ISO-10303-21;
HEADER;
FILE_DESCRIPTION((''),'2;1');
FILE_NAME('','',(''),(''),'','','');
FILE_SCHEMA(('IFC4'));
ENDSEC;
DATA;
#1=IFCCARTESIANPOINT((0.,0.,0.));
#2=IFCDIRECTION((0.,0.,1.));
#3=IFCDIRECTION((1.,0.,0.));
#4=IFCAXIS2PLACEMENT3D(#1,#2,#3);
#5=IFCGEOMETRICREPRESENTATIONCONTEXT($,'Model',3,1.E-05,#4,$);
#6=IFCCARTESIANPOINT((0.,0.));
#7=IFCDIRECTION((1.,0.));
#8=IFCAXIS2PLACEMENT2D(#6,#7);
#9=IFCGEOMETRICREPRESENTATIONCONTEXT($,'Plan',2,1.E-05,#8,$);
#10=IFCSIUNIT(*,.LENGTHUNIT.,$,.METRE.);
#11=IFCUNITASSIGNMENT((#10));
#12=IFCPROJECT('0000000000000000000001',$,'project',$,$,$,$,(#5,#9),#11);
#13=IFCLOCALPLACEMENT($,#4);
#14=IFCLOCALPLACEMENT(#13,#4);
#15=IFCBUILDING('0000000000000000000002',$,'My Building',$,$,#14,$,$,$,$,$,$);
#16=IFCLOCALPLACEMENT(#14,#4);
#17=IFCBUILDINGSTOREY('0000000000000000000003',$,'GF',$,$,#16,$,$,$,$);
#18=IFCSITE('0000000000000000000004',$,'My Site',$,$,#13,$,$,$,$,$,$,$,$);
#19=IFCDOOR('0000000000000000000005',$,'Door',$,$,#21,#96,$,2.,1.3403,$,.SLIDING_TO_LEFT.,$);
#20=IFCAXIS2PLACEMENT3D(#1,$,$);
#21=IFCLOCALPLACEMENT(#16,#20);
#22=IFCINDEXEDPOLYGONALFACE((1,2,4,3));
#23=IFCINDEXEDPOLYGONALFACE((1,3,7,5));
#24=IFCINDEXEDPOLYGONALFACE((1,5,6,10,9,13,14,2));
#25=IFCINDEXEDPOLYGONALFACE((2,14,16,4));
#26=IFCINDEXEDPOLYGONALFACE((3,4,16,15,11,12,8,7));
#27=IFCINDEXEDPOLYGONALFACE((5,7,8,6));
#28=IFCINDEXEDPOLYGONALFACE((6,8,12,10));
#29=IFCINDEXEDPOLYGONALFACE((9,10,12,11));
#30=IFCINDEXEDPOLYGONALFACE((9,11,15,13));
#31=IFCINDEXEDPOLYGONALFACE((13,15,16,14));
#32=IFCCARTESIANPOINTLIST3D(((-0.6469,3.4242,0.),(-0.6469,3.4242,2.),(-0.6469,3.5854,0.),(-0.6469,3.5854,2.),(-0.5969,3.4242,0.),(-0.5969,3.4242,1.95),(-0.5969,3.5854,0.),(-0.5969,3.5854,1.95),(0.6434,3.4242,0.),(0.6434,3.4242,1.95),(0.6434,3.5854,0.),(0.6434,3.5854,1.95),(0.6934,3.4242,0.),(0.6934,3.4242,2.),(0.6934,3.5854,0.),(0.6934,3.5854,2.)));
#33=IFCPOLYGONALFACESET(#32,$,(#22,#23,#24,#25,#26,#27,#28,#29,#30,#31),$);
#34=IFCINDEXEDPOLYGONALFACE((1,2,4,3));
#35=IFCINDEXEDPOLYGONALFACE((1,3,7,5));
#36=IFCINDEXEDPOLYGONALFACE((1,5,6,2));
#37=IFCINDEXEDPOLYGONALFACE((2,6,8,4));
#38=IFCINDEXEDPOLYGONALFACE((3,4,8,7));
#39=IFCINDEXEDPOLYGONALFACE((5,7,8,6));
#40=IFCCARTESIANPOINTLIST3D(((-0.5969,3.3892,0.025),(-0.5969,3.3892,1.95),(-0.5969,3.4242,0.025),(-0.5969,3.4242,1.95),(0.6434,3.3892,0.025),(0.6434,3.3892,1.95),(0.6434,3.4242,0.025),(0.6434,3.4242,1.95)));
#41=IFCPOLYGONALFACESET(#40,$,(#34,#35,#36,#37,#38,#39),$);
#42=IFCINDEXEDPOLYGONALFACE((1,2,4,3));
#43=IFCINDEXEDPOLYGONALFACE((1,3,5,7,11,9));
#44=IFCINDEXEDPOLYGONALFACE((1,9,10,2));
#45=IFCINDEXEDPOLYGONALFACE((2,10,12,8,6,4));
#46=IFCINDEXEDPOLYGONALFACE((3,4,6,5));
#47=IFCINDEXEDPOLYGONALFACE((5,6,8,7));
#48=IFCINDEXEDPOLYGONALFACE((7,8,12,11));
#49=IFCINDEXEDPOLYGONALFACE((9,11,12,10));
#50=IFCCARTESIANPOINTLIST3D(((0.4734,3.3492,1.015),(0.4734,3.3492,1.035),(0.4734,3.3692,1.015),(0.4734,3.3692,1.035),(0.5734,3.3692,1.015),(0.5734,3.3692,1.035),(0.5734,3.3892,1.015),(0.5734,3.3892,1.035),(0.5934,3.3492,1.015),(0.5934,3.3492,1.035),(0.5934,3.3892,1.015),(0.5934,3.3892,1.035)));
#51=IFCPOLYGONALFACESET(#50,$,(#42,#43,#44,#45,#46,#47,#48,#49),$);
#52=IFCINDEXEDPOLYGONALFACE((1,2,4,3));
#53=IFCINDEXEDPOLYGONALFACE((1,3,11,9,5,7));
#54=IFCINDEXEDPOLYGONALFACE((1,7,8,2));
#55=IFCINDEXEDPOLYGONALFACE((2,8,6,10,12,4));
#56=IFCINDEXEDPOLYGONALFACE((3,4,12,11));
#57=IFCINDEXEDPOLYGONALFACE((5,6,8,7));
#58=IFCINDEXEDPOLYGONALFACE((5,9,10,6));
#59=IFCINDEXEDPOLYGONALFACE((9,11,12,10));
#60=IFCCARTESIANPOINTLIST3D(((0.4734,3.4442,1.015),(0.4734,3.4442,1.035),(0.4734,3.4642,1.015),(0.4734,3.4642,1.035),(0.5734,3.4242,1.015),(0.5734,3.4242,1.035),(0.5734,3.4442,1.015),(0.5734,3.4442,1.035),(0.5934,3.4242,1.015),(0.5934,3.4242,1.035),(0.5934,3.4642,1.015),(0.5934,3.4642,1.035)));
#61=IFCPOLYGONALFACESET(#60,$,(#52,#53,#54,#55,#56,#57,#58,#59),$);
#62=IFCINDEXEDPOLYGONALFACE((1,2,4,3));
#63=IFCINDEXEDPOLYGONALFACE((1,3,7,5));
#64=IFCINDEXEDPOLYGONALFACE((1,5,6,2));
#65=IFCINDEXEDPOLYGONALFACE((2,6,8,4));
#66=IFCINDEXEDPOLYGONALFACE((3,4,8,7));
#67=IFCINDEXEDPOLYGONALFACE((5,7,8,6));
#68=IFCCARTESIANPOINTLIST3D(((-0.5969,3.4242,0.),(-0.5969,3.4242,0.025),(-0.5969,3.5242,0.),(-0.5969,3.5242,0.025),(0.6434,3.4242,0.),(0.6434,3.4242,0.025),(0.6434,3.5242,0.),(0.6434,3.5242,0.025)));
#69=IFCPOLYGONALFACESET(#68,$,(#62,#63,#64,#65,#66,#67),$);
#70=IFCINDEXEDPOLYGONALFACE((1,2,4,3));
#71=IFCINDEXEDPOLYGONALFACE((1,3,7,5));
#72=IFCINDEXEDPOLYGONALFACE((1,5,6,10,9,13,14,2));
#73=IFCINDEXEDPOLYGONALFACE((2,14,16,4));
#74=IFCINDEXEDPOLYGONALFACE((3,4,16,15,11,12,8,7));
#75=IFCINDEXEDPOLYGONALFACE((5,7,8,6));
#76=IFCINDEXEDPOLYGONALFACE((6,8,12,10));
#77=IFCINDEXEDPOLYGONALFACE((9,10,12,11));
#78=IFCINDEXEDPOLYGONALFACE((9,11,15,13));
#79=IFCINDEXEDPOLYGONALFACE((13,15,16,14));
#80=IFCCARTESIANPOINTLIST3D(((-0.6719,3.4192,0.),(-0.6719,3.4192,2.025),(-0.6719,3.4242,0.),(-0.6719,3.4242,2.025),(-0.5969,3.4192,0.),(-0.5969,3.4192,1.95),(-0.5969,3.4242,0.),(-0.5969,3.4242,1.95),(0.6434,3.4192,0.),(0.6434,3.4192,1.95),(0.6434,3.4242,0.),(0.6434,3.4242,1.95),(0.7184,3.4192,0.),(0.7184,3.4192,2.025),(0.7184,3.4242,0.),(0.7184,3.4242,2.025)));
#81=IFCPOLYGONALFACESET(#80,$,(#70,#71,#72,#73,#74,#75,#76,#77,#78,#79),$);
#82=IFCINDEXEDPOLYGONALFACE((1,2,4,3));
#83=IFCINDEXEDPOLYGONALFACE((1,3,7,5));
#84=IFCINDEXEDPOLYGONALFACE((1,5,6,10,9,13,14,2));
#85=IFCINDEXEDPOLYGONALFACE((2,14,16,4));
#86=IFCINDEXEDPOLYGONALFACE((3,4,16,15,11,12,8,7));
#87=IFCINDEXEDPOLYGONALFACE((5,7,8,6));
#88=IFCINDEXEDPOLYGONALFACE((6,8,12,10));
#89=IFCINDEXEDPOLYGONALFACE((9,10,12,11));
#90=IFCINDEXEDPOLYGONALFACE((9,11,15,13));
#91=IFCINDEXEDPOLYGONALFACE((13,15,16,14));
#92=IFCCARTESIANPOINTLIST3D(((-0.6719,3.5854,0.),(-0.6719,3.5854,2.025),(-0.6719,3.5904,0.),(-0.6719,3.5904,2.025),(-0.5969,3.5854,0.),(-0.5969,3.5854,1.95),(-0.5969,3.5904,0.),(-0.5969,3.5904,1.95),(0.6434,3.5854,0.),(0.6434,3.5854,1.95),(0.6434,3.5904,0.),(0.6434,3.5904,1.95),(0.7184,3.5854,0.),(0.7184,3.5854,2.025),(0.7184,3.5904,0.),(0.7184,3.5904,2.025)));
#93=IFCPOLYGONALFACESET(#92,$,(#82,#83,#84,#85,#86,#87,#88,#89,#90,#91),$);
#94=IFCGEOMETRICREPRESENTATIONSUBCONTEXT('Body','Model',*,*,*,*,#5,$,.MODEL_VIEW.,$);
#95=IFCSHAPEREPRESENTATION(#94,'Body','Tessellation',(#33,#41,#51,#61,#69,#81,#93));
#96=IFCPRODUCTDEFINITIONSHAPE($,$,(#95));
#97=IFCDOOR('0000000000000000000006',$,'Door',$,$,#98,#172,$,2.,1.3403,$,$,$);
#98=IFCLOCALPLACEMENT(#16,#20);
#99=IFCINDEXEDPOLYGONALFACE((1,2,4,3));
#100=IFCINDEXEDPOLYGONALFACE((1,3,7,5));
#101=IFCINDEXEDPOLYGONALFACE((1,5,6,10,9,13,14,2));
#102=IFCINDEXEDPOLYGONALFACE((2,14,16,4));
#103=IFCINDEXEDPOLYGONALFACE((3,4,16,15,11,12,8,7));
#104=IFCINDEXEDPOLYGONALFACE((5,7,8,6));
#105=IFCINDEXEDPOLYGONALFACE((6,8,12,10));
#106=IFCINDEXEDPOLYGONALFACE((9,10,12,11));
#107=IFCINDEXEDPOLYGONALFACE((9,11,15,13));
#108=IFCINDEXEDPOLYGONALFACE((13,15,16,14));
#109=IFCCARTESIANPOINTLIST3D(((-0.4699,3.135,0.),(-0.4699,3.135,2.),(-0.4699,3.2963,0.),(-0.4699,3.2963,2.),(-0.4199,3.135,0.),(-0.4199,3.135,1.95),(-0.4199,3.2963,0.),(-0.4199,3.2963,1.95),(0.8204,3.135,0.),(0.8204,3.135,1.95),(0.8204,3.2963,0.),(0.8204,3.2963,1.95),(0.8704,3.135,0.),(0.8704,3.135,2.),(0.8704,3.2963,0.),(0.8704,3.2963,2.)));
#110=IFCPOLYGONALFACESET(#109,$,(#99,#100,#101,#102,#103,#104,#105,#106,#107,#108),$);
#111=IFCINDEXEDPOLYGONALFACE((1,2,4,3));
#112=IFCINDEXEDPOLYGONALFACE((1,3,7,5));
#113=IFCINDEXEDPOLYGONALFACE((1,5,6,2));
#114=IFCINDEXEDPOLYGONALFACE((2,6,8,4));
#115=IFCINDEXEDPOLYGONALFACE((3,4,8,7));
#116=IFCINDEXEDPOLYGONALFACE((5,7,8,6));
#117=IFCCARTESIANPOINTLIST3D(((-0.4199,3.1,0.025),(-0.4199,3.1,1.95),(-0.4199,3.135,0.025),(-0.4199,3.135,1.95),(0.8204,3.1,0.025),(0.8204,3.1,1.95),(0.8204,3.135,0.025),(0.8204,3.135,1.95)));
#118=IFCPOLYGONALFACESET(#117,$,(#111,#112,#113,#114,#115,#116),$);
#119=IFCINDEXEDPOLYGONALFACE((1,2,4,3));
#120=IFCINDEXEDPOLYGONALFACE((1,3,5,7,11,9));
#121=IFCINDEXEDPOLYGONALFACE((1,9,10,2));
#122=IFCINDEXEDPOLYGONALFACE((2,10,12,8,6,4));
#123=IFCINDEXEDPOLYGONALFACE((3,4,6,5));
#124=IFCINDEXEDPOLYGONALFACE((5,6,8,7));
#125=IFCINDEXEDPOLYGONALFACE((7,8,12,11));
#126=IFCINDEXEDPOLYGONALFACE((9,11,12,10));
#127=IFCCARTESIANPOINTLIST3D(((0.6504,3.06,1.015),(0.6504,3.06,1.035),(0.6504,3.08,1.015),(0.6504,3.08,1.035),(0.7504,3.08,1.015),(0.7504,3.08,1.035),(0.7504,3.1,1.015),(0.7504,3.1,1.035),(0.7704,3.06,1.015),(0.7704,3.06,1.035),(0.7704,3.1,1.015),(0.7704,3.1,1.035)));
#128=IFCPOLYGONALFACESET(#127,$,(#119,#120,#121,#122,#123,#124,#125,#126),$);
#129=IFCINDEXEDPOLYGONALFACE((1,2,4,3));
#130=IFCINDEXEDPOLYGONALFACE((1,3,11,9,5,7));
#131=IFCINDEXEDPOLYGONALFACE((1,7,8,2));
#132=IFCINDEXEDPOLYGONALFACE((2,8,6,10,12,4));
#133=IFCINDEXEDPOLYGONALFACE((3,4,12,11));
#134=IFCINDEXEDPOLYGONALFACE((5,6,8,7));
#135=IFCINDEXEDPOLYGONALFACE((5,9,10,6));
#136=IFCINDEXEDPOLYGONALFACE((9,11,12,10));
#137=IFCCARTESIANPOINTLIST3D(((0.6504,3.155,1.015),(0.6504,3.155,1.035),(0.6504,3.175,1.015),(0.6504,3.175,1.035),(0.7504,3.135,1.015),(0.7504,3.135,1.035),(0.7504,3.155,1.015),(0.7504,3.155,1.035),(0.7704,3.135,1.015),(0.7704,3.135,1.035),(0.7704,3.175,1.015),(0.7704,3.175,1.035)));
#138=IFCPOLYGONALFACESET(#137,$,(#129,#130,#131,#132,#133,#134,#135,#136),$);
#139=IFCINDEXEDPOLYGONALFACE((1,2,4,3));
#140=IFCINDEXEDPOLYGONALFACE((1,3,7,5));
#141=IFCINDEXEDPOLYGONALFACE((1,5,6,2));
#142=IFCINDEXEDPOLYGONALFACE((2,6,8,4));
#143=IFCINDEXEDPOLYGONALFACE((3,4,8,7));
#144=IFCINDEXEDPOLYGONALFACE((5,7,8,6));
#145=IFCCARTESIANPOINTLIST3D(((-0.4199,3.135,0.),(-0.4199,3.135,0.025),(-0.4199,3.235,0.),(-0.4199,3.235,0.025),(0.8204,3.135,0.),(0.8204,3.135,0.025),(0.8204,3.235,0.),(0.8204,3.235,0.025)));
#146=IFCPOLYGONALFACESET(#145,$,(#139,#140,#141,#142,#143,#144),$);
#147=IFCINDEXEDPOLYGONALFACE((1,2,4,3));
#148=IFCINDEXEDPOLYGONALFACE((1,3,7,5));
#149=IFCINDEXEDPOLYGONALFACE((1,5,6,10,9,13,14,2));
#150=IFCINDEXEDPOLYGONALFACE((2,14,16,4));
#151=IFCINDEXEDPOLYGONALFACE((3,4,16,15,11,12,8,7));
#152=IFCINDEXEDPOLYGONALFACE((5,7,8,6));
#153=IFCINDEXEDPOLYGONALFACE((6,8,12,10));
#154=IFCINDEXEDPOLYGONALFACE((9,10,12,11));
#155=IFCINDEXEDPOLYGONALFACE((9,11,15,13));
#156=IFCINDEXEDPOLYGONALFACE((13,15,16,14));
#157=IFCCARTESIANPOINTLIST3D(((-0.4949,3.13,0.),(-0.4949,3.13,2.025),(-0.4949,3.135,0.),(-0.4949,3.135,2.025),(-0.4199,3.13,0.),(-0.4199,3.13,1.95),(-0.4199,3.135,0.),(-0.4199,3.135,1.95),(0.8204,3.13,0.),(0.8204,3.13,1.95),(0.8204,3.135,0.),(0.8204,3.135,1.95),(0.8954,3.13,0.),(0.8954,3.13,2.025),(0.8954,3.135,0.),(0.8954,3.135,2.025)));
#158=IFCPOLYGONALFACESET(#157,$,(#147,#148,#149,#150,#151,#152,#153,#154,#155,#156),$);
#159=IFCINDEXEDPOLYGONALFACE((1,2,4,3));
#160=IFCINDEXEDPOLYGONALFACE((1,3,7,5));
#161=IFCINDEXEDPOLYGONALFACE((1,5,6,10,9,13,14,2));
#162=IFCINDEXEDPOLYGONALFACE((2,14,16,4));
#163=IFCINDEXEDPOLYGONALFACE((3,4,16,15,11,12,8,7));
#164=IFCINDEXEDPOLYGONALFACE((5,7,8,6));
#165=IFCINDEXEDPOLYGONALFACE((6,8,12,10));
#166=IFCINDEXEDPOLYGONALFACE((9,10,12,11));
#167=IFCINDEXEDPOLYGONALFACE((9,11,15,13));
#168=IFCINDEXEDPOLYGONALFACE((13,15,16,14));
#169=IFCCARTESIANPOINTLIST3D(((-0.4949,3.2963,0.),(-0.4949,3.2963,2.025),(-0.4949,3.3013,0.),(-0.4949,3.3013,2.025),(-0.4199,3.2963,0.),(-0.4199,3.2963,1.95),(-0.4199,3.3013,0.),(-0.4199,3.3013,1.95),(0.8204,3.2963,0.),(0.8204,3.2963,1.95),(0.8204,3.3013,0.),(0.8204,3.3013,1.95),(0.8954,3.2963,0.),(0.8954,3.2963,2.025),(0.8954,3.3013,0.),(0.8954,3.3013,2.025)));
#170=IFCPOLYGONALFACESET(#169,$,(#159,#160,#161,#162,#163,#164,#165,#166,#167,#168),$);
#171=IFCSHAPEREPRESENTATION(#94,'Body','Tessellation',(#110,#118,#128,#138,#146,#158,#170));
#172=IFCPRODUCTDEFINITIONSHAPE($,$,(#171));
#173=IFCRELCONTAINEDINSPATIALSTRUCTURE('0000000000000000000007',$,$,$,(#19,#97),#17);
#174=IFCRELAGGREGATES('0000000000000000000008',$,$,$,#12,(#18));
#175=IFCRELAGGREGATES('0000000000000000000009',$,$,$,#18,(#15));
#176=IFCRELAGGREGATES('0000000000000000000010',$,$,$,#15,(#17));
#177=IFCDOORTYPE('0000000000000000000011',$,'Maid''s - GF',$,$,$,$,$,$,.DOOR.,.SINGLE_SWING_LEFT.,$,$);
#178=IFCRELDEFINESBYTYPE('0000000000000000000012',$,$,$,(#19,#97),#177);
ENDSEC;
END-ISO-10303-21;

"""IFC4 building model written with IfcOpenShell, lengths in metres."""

from ifc_helpers import new_model, entity, si_unit, frame, origin_with_axes, origin_2d_with_axis, place, context, subcontext, project, spatial, line, indexed_curve, outline, extrude, shape, source, transform, mapped, type_object, type_shapes, element, save


model = new_model("IFC4")

# Units and contexts
model_context = context("Model", 3, precision=1e-05, world=origin_with_axes())
plan_context = context("Plan", 2, precision=1e-05, world=origin_2d_with_axis())
body_context_1 = subcontext(model_context, "Body", "Model", "MODEL_VIEW")
body_context_2 = subcontext(plan_context, "Body", "Plan", "PLAN_VIEW")
ifc_project = project(units=[si_unit("LENGTHUNIT", "METRE")], contexts=[model_context, plan_context])

# Site, building, storey
site_placement = place(None, origin_with_axes())
site = spatial("IfcSite", under=ifc_project, at=site_placement, Name="My Site")
building_placement = place(site_placement, origin_with_axes())
building = spatial("IfcBuilding", under=site, at=building_placement, Name="My Building")
storey_placement = place(building_placement, origin_with_axes())
storey = spatial("IfcBuildingStorey", under=building, at=storey_placement, Name="GF")

# Doors
door_type_1 = type_object("IfcDoorType", Name="Maid's - GF", OperationType="SINGLE_SWING_LEFT", PredefinedType="DOOR")
shared_shape_1 = source(origin_with_axes(), body_context_1, "Body", "SweptSolid", [
    extrude(outline(indexed_curve([(0.0, 0.0), (0.0, 2.0), (1.3403, 2.0), (1.3403, 0.0), (1.2903, 0.0), (1.2903, 1.95), (0.05, 1.95), (0.05, 0.0)], segments=[line(1, 2, 3, 4, 5, 6, 7, 8, 1)])), frame((0.0, 0.0, 0.0), z_axis=(0.0, -1.0, 0.0), x_axis=(1.0, 0.0, 0.0)), (0.0, 0.0, -1.0), 0.1612),
    extrude(outline(indexed_curve([(0.0, 0.0), (1.2403, 0.0), (1.2403, 0.035), (0.0, 0.035)], segments=[line(1, 2, 3, 4, 1)])), frame((0.05, -0.035, 0.025), z_axis=(0.0, 0.0, 1.0), x_axis=(1.0, 0.0, 0.0)), (0.0, 0.0, 1.0), 1.925),
    extrude(outline(indexed_curve([(0.0, 0.0), (0.0, -0.04), (-0.12, -0.04), (-0.12, -0.02), (-0.02, -0.02), (-0.02, 0.0)], segments=[line(1, 2, 3, 4, 5, 6, 1)])), frame((1.2403, -0.035, 1.015), z_axis=(0.0, 0.0, 1.0), x_axis=(1.0, 0.0, 0.0)), (0.0, 0.0, 1.0), 0.02),
    extrude(outline(indexed_curve([(0.0, 0.0), (0.0, 0.04), (-0.12, 0.04), (-0.12, 0.02), (-0.02, 0.02), (-0.02, 0.0)], segments=[line(1, 2, 3, 4, 5, 6, 1)])), frame((1.2403, 0.0, 1.015), z_axis=(0.0, 0.0, 1.0), x_axis=(1.0, 0.0, 0.0)), (0.0, 0.0, 1.0), 0.02),
    extrude(outline(indexed_curve([(0.0, 0.0), (1.2403, 0.0), (1.2403, 0.1), (0.0, 0.1)], segments=[line(1, 2, 3, 4, 1)])), frame((0.05, 0.0, 0.0), z_axis=(0.0, 0.0, 1.0), x_axis=(1.0, 0.0, 0.0)), (0.0, 0.0, 1.0), 0.025),
    extrude(outline(indexed_curve([(0.0, 0.0), (0.0, 2.025), (1.3903, 2.025), (1.3903, 0.0), (1.3153, 0.0), (1.3153, 1.95), (0.075, 1.95), (0.075, 0.0)], segments=[line(1, 2, 3, 4, 5, 6, 7, 8, 1)])), frame((-0.025, -0.005, 0.0), z_axis=(0.0, -1.0, 0.0), x_axis=(1.0, 0.0, 0.0)), (0.0, 0.0, -1.0), 0.005),
    extrude(outline(indexed_curve([(0.0, 0.0), (0.0, 2.025), (1.3903, 2.025), (1.3903, 0.0), (1.3153, 0.0), (1.3153, 1.95), (0.075, 1.95), (0.075, 0.0)], segments=[line(1, 2, 3, 4, 5, 6, 7, 8, 1)])), frame((-0.025, 0.1612, 0.0), z_axis=(0.0, -1.0, 0.0), x_axis=(1.0, 0.0, 0.0)), (0.0, 0.0, -1.0), 0.005),
])
shared_shape_2 = source(origin_with_axes(), body_context_2, "Body", "Curve2D", [
    entity("IfcIndexedPolyCurve", entity("IfcCartesianPointList2D", [[0.0, 0.0], [0.05, 0.0], [0.05, 0.1612], [0.0, 0.1612]]), [entity("IfcLineIndex", [1, 2, 3, 4, 1])]),
    entity("IfcIndexedPolyCurve", entity("IfcCartesianPointList2D", [[1.3403, 0.0], [1.2903, 0.0], [1.2903, 0.1612], [1.3403, 0.1612]]), [entity("IfcLineIndex", [1, 2, 3, 4, 1])]),
    entity("IfcIndexedPolyCurve", entity("IfcCartesianPointList2D", [[-0.5702, -0.035], [0.6702, -0.035], [0.6702, 0.0], [-0.5702, 0.0]]), [entity("IfcLineIndex", [1, 2, 3, 4, 1])]),
])
type_shapes(door_type_1, [shared_shape_1, shared_shape_2])
door_1_placement = place(storey_placement, frame((-0.6469, 3.4242, 0.0), z_axis=(0.0, 0.0, 1.0), x_axis=(1.0, -0.000001, 0.0)))
element("IfcDoor", 1, at=door_1_placement, inside=storey, type_object=door_type_1, Name="Door", OperationType="SLIDING_TO_LEFT", OverallHeight=2.0, OverallWidth=1.3403, shapes=[
    shape(body_context_1, "Body", "MappedRepresentation", [mapped(shared_shape_1, transform((0.0, 0.0, 0.0), x_axis=(1.0, 0.0, 0.0), y_axis=(0.0, 1.0, 0.0), z_axis=(0.0, 0.0, 1.0), scale=1.0))]),
    shape(body_context_2, "Body", "MappedRepresentation", [mapped(shared_shape_2, transform((0.0, 0.0, 0.0), x_axis=(1.0, 0.0, 0.0), y_axis=(0.0, 1.0, 0.0), z_axis=(0.0, 0.0, 1.0), scale=1.0))]),
])
door_2_placement = place(storey_placement, frame((-0.4699, 3.135, 0.0), z_axis=(0.0, 0.0, 1.0), x_axis=(1.0, 0.0, 0.0)))
element("IfcDoor", 2, at=door_2_placement, inside=storey, type_object=door_type_1, Name="Door", OverallHeight=2.0, OverallWidth=1.3403, shapes=[
    shape(body_context_1, "Body", "MappedRepresentation", [mapped(shared_shape_1, transform((0.0, 0.0, 0.0), x_axis=(1.0, 0.0, 0.0), y_axis=(0.0, 1.0, 0.0), z_axis=(0.0, 0.0, 1.0), scale=1.0))]),
    shape(body_context_2, "Body", "MappedRepresentation", [mapped(shared_shape_2, transform((0.0, 0.0, 0.0), x_axis=(1.0, 0.0, 0.0), y_axis=(0.0, 1.0, 0.0), z_axis=(0.0, 0.0, 1.0), scale=1.0))]),
])

save(model, "model.ifc")
